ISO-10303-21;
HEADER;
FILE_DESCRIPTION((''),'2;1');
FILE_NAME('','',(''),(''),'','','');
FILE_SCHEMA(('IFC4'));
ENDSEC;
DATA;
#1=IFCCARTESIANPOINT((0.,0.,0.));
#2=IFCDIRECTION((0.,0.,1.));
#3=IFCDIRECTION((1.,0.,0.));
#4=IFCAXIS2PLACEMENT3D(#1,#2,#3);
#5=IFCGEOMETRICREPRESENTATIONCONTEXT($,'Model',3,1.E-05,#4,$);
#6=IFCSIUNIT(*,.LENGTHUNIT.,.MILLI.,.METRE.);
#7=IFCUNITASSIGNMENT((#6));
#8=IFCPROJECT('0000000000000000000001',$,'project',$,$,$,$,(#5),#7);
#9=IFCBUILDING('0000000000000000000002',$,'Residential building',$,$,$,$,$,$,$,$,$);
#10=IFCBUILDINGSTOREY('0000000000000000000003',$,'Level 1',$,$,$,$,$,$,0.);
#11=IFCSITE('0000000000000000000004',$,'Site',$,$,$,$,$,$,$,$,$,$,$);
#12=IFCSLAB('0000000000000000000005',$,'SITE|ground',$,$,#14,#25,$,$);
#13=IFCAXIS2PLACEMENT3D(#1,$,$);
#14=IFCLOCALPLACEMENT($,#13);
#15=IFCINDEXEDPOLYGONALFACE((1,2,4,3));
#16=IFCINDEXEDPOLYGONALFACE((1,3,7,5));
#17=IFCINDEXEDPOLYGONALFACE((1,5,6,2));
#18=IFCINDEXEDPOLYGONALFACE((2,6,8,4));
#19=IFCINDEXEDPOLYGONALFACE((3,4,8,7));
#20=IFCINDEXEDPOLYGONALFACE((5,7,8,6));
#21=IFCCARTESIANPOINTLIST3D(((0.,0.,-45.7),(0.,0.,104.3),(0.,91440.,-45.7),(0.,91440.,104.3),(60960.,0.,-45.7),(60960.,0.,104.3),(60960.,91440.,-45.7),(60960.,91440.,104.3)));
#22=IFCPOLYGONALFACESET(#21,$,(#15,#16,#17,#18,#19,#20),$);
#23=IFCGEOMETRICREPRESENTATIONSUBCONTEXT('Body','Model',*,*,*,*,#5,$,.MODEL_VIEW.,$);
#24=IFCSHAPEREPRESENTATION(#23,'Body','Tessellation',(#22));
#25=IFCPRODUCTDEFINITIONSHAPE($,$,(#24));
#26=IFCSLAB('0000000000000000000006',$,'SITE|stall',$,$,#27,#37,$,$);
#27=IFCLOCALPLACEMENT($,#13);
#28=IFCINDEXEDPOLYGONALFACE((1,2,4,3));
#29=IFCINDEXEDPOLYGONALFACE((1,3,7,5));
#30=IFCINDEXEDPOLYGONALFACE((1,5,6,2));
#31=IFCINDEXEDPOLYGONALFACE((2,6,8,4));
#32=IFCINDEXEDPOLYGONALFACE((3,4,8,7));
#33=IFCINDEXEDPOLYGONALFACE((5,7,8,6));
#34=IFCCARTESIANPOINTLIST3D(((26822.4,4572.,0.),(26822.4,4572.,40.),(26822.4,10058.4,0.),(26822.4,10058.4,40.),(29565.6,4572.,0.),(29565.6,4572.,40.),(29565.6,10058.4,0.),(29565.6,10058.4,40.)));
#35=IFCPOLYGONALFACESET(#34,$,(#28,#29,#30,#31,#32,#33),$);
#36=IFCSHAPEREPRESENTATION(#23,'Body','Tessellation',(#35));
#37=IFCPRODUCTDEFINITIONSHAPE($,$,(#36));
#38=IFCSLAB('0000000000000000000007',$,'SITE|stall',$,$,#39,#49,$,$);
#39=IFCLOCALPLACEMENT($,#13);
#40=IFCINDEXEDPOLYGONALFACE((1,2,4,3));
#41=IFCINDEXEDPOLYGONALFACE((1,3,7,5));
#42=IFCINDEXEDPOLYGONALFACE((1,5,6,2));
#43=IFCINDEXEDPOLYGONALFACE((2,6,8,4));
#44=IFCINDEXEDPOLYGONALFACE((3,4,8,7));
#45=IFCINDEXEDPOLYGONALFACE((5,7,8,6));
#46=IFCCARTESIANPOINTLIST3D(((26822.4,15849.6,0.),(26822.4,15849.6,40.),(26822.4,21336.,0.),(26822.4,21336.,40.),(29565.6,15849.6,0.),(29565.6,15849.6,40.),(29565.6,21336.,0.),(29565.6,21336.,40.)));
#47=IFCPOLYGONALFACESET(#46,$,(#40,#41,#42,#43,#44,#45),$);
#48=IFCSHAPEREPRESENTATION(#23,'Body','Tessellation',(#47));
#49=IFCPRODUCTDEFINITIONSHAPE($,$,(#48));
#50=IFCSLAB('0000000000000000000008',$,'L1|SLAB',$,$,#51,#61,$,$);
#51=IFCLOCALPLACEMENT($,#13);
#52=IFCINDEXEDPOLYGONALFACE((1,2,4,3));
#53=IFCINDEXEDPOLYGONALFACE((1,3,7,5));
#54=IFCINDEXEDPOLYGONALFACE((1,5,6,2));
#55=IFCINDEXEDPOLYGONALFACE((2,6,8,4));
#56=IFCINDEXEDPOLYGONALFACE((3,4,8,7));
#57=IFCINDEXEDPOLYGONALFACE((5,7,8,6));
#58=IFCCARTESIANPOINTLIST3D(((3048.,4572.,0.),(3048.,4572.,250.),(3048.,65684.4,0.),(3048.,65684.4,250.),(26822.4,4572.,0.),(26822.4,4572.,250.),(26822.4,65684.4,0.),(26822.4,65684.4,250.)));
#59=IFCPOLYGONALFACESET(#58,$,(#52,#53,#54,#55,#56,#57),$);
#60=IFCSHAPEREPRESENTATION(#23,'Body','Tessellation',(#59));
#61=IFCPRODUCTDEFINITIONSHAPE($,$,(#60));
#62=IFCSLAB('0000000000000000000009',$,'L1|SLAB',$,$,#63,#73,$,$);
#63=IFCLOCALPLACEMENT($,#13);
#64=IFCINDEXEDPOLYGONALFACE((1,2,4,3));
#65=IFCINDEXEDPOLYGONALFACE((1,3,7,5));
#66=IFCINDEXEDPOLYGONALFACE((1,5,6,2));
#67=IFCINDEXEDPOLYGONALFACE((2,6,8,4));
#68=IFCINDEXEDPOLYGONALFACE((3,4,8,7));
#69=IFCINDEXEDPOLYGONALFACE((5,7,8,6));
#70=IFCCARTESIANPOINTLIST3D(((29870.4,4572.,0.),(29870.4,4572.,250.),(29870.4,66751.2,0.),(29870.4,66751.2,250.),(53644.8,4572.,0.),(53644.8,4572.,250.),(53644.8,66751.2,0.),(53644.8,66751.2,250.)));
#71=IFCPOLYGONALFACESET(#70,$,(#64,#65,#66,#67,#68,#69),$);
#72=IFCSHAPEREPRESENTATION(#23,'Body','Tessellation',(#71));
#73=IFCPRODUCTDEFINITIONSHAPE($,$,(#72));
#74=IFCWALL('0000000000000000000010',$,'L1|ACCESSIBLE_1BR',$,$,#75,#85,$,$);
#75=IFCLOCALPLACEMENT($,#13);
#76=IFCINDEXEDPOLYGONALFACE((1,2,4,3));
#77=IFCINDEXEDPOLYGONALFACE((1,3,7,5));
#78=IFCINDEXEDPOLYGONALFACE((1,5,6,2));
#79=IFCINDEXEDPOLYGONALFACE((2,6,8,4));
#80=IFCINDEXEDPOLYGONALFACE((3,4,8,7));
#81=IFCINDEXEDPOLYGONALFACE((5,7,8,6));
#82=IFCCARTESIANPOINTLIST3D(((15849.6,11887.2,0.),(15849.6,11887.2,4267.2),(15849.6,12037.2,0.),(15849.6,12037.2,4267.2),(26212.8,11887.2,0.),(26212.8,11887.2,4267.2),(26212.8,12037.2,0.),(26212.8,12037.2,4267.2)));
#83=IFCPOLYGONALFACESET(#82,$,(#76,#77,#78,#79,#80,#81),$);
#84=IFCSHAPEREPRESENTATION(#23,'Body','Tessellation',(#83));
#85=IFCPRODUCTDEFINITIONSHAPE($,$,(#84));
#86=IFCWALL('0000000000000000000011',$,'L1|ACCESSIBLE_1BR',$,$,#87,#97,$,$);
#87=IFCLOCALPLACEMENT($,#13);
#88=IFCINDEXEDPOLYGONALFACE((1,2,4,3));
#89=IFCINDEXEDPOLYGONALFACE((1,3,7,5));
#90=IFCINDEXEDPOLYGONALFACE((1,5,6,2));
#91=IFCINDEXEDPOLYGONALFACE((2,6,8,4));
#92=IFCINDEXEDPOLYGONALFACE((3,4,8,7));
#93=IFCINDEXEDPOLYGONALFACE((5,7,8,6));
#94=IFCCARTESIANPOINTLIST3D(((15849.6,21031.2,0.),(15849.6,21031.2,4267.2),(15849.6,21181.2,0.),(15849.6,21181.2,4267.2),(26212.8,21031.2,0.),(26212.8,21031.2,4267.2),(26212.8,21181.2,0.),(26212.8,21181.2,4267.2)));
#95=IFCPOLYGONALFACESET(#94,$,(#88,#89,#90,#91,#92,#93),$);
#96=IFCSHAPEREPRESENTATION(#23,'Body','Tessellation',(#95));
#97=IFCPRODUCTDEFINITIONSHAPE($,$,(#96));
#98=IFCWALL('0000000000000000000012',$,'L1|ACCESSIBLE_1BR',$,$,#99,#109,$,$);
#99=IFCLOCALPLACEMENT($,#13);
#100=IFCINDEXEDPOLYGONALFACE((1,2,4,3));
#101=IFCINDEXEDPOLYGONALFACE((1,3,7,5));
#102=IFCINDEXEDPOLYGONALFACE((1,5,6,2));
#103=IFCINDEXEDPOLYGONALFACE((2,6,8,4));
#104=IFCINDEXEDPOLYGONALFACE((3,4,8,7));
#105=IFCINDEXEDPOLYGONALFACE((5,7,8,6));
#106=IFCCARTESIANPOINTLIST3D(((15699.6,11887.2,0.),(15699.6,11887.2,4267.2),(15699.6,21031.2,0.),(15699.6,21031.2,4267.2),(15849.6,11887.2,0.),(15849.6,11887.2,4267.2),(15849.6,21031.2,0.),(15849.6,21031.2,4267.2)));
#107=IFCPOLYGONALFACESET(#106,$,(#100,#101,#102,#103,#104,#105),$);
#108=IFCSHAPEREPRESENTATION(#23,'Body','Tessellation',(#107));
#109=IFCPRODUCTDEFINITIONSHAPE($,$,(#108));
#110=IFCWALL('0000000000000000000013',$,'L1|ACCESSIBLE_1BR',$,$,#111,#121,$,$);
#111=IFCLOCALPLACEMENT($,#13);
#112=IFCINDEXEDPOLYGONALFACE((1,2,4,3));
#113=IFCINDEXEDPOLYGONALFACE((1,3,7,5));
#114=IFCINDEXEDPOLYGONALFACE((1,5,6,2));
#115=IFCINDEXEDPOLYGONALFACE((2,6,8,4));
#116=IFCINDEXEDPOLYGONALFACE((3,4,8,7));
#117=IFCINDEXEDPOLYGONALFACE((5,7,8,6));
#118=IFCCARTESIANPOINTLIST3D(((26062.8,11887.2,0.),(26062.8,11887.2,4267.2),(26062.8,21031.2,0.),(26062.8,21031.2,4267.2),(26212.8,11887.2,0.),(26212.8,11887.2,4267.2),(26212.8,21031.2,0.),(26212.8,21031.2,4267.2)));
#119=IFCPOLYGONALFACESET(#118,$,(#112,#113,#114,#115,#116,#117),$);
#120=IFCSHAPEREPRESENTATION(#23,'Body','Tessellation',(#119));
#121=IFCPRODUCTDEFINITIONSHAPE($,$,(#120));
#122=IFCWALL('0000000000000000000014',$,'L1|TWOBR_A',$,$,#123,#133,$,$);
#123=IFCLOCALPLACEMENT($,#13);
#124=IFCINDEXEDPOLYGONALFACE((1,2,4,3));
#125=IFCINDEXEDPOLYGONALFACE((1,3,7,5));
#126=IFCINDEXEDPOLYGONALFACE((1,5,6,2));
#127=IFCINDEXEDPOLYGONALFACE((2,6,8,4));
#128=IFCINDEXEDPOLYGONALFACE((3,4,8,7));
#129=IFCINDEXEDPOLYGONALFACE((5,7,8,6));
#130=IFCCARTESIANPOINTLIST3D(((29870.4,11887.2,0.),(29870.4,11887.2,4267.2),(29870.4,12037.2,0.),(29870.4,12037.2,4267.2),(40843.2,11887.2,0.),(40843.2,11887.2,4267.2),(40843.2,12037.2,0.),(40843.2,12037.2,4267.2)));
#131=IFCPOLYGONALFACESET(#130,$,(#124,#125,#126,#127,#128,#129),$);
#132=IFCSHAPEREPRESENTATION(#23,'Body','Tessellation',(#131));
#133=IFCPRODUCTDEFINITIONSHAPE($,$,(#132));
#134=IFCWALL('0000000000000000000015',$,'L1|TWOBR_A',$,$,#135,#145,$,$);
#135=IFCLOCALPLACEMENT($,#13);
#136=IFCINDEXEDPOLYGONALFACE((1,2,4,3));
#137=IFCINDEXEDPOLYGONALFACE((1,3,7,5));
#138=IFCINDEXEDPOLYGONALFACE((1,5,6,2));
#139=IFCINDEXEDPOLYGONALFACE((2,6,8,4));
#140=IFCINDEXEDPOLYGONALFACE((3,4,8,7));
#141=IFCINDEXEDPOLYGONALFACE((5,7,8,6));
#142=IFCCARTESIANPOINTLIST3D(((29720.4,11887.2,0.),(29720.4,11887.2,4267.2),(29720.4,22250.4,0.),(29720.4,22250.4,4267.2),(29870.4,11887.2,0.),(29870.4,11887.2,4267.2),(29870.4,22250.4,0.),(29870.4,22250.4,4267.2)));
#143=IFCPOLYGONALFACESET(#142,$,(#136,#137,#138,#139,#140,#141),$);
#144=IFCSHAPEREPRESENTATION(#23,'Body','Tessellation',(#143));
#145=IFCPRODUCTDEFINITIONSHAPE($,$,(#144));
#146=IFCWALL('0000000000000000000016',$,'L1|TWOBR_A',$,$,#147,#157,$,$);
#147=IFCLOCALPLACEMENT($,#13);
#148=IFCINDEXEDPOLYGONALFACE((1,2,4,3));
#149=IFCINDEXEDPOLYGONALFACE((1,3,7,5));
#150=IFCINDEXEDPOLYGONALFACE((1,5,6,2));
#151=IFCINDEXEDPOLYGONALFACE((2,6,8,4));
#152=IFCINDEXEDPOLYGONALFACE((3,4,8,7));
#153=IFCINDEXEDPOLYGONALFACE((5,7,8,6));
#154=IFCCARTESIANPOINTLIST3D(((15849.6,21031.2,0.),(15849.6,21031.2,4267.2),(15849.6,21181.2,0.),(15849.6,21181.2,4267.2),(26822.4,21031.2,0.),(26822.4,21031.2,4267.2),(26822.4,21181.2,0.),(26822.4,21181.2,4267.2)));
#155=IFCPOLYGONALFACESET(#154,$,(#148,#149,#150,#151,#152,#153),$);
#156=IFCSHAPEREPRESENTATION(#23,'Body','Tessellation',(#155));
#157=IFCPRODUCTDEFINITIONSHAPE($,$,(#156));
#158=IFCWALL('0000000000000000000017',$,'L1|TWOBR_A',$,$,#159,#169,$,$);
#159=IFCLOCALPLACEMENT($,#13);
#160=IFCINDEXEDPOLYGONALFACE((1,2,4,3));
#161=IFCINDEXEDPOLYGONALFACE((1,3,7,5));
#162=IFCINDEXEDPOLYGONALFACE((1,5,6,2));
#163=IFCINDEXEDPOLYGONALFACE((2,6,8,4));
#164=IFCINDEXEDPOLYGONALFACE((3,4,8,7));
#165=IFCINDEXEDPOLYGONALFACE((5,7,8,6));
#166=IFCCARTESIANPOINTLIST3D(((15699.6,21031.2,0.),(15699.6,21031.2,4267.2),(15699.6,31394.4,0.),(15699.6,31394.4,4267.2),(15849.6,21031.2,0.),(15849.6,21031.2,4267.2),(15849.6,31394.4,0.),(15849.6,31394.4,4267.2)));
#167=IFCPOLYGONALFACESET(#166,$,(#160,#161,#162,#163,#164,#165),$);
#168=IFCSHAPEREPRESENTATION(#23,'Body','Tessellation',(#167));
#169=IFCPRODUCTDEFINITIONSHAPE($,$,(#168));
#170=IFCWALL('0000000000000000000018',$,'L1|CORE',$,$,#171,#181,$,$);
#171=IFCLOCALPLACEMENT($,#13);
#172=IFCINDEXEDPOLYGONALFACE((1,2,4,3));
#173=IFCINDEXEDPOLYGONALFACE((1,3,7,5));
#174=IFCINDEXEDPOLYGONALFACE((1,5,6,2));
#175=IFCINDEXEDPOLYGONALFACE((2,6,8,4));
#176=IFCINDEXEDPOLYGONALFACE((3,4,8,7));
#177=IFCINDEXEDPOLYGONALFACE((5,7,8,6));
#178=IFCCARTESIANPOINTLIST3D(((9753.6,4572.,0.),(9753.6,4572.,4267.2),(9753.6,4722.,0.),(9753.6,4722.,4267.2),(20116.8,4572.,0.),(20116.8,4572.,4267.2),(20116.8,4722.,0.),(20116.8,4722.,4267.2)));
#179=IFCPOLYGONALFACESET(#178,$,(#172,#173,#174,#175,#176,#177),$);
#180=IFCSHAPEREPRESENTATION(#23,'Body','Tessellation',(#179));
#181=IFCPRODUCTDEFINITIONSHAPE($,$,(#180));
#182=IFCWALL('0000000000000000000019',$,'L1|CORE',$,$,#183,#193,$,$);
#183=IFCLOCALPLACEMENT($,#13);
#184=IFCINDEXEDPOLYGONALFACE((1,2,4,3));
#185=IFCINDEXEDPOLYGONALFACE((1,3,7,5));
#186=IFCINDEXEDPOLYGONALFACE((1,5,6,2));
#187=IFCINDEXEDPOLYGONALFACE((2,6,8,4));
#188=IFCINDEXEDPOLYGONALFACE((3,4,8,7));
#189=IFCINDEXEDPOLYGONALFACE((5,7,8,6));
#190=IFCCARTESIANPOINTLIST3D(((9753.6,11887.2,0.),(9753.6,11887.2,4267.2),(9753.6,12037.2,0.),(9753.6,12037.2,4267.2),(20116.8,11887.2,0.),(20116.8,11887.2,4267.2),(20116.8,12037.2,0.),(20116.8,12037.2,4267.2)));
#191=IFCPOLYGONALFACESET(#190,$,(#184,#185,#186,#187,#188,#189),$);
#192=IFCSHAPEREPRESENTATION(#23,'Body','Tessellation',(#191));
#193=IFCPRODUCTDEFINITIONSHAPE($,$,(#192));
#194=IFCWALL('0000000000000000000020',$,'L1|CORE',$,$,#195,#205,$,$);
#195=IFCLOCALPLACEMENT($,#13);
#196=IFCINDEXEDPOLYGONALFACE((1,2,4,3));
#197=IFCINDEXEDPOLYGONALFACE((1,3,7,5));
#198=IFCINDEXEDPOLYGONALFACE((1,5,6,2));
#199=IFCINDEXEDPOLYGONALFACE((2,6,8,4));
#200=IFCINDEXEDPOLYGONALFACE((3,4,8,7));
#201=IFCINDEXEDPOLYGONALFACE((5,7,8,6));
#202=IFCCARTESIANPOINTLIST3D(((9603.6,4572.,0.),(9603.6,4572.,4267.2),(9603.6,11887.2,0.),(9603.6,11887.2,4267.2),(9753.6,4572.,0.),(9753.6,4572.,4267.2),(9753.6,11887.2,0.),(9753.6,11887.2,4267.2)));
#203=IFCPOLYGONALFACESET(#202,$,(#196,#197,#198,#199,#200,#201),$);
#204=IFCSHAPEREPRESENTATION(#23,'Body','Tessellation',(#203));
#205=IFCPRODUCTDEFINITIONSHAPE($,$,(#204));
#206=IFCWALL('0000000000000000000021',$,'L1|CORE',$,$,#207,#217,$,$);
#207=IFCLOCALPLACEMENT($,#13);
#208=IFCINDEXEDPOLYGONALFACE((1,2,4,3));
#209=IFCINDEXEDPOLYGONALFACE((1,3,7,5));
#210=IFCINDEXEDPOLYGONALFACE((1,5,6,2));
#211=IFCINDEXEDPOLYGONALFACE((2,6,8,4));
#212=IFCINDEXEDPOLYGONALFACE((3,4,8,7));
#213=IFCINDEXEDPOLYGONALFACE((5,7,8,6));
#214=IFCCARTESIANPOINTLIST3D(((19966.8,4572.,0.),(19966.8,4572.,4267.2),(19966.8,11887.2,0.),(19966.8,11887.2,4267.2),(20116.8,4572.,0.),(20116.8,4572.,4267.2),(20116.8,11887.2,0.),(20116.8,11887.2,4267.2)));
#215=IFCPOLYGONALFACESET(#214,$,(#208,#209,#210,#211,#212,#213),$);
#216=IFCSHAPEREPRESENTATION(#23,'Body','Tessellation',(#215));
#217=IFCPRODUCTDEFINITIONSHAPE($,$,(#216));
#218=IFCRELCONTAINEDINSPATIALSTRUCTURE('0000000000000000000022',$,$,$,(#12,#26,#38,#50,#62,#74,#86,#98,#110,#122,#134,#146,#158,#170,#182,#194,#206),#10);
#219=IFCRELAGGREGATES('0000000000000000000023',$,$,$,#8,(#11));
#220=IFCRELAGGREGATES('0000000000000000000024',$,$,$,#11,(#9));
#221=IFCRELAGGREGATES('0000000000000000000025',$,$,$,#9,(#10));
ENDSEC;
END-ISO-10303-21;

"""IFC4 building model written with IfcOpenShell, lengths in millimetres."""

from ifc_helpers import new_model, si_unit, frame, origin_with_axes, place, context, subcontext, project, spatial, indexed_curve, outline, extrude, element, save


model = new_model("IFC4")

# Units and contexts
model_context = context("Model", 3, precision=1e-05, world=origin_with_axes())
body_context = subcontext(model_context, "Body", "Model", "MODEL_VIEW")
ifc_project = project(units=[si_unit("LENGTHUNIT", "METRE", prefix="MILLI")], contexts=[model_context])

# Site, building, storey
site = spatial("IfcSite", under=ifc_project, Name="Site")
building = spatial("IfcBuilding", under=site, Name="Residential building")
storey = spatial("IfcBuildingStorey", under=building, Name="Level 1", Elevation=0.0)

# Slabs
slab_1_placement = place(None, frame((0.0, 0.0, -45.7), z_axis=(0.0, 0.0, 1.0), x_axis=(1.0, 0.0, 0.0)))
element("IfcSlab", 1, at=slab_1_placement, inside=storey, Name="SITE|ground", context=body_context, shape_type="SweptSolid", body=[
    extrude(outline(indexed_curve([(0.0, 0.0), (60960.0, 0.0), (60960.0, 91440.0), (0.0, 91440.0), (0.0, 0.0)])), None, (0.0, 0.0, 1.0), 150.0),
])
for number, where, z_axis, x_axis, name in (
    (2, (26822.4, 4572.0, 0.0), (0.0, 0.0, 1.0), (1.0, 0.0, 0.0), "SITE|stall"),
    (3, (26822.4, 15849.6, 0.0), (0.0, 0.0, 1.0), (1.0, 0.0, 0.0), "SITE|stall"),
):
    element("IfcSlab", number, at=place(None, frame(where, z_axis=z_axis, x_axis=x_axis)), inside=storey, Name=name, context=body_context, shape_type="SweptSolid", body=[
        extrude(outline(indexed_curve([(0.0, 0.0), (2743.2, 0.0), (2743.2, 5486.4), (0.0, 5486.4), (0.0, 0.0)])), None, (0.0, 0.0, 1.0), 40.0),
    ])
slab_2_placement = place(None, frame((3048.0, 4572.0, 0.0), z_axis=(0.0, 0.0, 1.0), x_axis=(1.0, 0.0, 0.0)))
element("IfcSlab", 4, at=slab_2_placement, inside=storey, Name="L1|SLAB", context=body_context, shape_type="SweptSolid", body=[
    extrude(outline(indexed_curve([(0.0, 0.0), (23774.4, 0.0), (23774.4, 61112.4), (0.0, 61112.4), (0.0, 0.0)])), None, (0.0, 0.0, 1.0), 250.0),
])
slab_3_placement = place(None, frame((29870.4, 4572.0, 0.0), z_axis=(0.0, 0.0, 1.0), x_axis=(1.0, 0.0, 0.0)))
element("IfcSlab", 5, at=slab_3_placement, inside=storey, Name="L1|SLAB", context=body_context, shape_type="SweptSolid", body=[
    extrude(outline(indexed_curve([(0.0, 0.0), (23774.4, 0.0), (23774.4, 62179.2), (0.0, 62179.2), (0.0, 0.0)])), None, (0.0, 0.0, 1.0), 250.0),
])

# Walls
for number, where, z_axis, x_axis, name in (
    (6, (15849.6, 11887.2, 0.0), (0.0, 0.0, 1.0), (1.0, 0.0, 0.0), "L1|ACCESSIBLE_1BR"),
    (7, (15849.6, 21031.2, 0.0), (0.0, 0.0, 1.0), (1.0, 0.0, 0.0), "L1|ACCESSIBLE_1BR"),
):
    element("IfcWall", number, at=place(None, frame(where, z_axis=z_axis, x_axis=x_axis)), inside=storey, Name=name, context=body_context, shape_type="SweptSolid", body=[
        extrude(outline(indexed_curve([(0.0, 0.0), (0.0, 150.0), (10363.2, 150.0), (10363.2, 0.0), (0.0, 0.0)], self_intersect=False)), origin_with_axes(), (0.0, 0.0, 1.0), 4267.2),
    ])
for number, where, z_axis, x_axis, name in (
    (8, (15849.6, 11887.2, 0.0), (0.0, 0.0, 1.0), (0.0, 1.0, 0.0), "L1|ACCESSIBLE_1BR"),
    (9, (26212.8, 11887.2, 0.0), (0.0, 0.0, 1.0), (0.0, 1.0, 0.0), "L1|ACCESSIBLE_1BR"),
):
    element("IfcWall", number, at=place(None, frame(where, z_axis=z_axis, x_axis=x_axis)), inside=storey, Name=name, context=body_context, shape_type="SweptSolid", body=[
        extrude(outline(indexed_curve([(0.0, 0.0), (0.0, 150.0), (9144.0, 150.0), (9144.0, 0.0), (0.0, 0.0)], self_intersect=False)), origin_with_axes(), (0.0, 0.0, 1.0), 4267.2),
    ])
wall_1_placement = place(None, frame((29870.4, 11887.2, 0.0), z_axis=(0.0, 0.0, 1.0), x_axis=(1.0, 0.0, 0.0)))
element("IfcWall", 10, at=wall_1_placement, inside=storey, Name="L1|TWOBR_A", context=body_context, shape_type="SweptSolid", body=[
    extrude(outline(indexed_curve([(0.0, 0.0), (0.0, 150.0), (10972.8, 150.0), (10972.8, 0.0), (0.0, 0.0)], self_intersect=False)), origin_with_axes(), (0.0, 0.0, 1.0), 4267.2),
])
wall_2_placement = place(None, frame((29870.4, 11887.2, 0.0), z_axis=(0.0, 0.0, 1.0), x_axis=(0.0, 1.0, 0.0)))
element("IfcWall", 11, at=wall_2_placement, inside=storey, Name="L1|TWOBR_A", context=body_context, shape_type="SweptSolid", body=[
    extrude(outline(indexed_curve([(0.0, 0.0), (0.0, 150.0), (10363.2, 150.0), (10363.2, 0.0), (0.0, 0.0)], self_intersect=False)), origin_with_axes(), (0.0, 0.0, 1.0), 4267.2),
])
wall_3_placement = place(None, frame((15849.6, 21031.2, 0.0), z_axis=(0.0, 0.0, 1.0), x_axis=(1.0, 0.0, 0.0)))
element("IfcWall", 12, at=wall_3_placement, inside=storey, Name="L1|TWOBR_A", context=body_context, shape_type="SweptSolid", body=[
    extrude(outline(indexed_curve([(0.0, 0.0), (0.0, 150.0), (10972.8, 150.0), (10972.8, 0.0), (0.0, 0.0)], self_intersect=False)), origin_with_axes(), (0.0, 0.0, 1.0), 4267.2),
])
for number, where, z_axis, x_axis, name in (
    (13, (15849.6, 21031.2, 0.0), (0.0, 0.0, 1.0), (0.0, 1.0, 0.0), "L1|TWOBR_A"),
    (14, (9753.6, 4572.0, 0.0), (0.0, 0.0, 1.0), (1.0, 0.0, 0.0), "L1|CORE"),
    (15, (9753.6, 11887.2, 0.0), (0.0, 0.0, 1.0), (1.0, 0.0, 0.0), "L1|CORE"),
):
    element("IfcWall", number, at=place(None, frame(where, z_axis=z_axis, x_axis=x_axis)), inside=storey, Name=name, context=body_context, shape_type="SweptSolid", body=[
        extrude(outline(indexed_curve([(0.0, 0.0), (0.0, 150.0), (10363.2, 150.0), (10363.2, 0.0), (0.0, 0.0)], self_intersect=False)), origin_with_axes(), (0.0, 0.0, 1.0), 4267.2),
    ])
for number, where, z_axis, x_axis, name in (
    (16, (9753.6, 4572.0, 0.0), (0.0, 0.0, 1.0), (0.0, 1.0, 0.0), "L1|CORE"),
    (17, (20116.8, 4572.0, 0.0), (0.0, 0.0, 1.0), (0.0, 1.0, 0.0), "L1|CORE"),
):
    element("IfcWall", number, at=place(None, frame(where, z_axis=z_axis, x_axis=x_axis)), inside=storey, Name=name, context=body_context, shape_type="SweptSolid", body=[
        extrude(outline(indexed_curve([(0.0, 0.0), (0.0, 150.0), (7315.2, 150.0), (7315.2, 0.0), (0.0, 0.0)], self_intersect=False)), origin_with_axes(), (0.0, 0.0, 1.0), 4267.2),
    ])

save(model, "model.ifc")
